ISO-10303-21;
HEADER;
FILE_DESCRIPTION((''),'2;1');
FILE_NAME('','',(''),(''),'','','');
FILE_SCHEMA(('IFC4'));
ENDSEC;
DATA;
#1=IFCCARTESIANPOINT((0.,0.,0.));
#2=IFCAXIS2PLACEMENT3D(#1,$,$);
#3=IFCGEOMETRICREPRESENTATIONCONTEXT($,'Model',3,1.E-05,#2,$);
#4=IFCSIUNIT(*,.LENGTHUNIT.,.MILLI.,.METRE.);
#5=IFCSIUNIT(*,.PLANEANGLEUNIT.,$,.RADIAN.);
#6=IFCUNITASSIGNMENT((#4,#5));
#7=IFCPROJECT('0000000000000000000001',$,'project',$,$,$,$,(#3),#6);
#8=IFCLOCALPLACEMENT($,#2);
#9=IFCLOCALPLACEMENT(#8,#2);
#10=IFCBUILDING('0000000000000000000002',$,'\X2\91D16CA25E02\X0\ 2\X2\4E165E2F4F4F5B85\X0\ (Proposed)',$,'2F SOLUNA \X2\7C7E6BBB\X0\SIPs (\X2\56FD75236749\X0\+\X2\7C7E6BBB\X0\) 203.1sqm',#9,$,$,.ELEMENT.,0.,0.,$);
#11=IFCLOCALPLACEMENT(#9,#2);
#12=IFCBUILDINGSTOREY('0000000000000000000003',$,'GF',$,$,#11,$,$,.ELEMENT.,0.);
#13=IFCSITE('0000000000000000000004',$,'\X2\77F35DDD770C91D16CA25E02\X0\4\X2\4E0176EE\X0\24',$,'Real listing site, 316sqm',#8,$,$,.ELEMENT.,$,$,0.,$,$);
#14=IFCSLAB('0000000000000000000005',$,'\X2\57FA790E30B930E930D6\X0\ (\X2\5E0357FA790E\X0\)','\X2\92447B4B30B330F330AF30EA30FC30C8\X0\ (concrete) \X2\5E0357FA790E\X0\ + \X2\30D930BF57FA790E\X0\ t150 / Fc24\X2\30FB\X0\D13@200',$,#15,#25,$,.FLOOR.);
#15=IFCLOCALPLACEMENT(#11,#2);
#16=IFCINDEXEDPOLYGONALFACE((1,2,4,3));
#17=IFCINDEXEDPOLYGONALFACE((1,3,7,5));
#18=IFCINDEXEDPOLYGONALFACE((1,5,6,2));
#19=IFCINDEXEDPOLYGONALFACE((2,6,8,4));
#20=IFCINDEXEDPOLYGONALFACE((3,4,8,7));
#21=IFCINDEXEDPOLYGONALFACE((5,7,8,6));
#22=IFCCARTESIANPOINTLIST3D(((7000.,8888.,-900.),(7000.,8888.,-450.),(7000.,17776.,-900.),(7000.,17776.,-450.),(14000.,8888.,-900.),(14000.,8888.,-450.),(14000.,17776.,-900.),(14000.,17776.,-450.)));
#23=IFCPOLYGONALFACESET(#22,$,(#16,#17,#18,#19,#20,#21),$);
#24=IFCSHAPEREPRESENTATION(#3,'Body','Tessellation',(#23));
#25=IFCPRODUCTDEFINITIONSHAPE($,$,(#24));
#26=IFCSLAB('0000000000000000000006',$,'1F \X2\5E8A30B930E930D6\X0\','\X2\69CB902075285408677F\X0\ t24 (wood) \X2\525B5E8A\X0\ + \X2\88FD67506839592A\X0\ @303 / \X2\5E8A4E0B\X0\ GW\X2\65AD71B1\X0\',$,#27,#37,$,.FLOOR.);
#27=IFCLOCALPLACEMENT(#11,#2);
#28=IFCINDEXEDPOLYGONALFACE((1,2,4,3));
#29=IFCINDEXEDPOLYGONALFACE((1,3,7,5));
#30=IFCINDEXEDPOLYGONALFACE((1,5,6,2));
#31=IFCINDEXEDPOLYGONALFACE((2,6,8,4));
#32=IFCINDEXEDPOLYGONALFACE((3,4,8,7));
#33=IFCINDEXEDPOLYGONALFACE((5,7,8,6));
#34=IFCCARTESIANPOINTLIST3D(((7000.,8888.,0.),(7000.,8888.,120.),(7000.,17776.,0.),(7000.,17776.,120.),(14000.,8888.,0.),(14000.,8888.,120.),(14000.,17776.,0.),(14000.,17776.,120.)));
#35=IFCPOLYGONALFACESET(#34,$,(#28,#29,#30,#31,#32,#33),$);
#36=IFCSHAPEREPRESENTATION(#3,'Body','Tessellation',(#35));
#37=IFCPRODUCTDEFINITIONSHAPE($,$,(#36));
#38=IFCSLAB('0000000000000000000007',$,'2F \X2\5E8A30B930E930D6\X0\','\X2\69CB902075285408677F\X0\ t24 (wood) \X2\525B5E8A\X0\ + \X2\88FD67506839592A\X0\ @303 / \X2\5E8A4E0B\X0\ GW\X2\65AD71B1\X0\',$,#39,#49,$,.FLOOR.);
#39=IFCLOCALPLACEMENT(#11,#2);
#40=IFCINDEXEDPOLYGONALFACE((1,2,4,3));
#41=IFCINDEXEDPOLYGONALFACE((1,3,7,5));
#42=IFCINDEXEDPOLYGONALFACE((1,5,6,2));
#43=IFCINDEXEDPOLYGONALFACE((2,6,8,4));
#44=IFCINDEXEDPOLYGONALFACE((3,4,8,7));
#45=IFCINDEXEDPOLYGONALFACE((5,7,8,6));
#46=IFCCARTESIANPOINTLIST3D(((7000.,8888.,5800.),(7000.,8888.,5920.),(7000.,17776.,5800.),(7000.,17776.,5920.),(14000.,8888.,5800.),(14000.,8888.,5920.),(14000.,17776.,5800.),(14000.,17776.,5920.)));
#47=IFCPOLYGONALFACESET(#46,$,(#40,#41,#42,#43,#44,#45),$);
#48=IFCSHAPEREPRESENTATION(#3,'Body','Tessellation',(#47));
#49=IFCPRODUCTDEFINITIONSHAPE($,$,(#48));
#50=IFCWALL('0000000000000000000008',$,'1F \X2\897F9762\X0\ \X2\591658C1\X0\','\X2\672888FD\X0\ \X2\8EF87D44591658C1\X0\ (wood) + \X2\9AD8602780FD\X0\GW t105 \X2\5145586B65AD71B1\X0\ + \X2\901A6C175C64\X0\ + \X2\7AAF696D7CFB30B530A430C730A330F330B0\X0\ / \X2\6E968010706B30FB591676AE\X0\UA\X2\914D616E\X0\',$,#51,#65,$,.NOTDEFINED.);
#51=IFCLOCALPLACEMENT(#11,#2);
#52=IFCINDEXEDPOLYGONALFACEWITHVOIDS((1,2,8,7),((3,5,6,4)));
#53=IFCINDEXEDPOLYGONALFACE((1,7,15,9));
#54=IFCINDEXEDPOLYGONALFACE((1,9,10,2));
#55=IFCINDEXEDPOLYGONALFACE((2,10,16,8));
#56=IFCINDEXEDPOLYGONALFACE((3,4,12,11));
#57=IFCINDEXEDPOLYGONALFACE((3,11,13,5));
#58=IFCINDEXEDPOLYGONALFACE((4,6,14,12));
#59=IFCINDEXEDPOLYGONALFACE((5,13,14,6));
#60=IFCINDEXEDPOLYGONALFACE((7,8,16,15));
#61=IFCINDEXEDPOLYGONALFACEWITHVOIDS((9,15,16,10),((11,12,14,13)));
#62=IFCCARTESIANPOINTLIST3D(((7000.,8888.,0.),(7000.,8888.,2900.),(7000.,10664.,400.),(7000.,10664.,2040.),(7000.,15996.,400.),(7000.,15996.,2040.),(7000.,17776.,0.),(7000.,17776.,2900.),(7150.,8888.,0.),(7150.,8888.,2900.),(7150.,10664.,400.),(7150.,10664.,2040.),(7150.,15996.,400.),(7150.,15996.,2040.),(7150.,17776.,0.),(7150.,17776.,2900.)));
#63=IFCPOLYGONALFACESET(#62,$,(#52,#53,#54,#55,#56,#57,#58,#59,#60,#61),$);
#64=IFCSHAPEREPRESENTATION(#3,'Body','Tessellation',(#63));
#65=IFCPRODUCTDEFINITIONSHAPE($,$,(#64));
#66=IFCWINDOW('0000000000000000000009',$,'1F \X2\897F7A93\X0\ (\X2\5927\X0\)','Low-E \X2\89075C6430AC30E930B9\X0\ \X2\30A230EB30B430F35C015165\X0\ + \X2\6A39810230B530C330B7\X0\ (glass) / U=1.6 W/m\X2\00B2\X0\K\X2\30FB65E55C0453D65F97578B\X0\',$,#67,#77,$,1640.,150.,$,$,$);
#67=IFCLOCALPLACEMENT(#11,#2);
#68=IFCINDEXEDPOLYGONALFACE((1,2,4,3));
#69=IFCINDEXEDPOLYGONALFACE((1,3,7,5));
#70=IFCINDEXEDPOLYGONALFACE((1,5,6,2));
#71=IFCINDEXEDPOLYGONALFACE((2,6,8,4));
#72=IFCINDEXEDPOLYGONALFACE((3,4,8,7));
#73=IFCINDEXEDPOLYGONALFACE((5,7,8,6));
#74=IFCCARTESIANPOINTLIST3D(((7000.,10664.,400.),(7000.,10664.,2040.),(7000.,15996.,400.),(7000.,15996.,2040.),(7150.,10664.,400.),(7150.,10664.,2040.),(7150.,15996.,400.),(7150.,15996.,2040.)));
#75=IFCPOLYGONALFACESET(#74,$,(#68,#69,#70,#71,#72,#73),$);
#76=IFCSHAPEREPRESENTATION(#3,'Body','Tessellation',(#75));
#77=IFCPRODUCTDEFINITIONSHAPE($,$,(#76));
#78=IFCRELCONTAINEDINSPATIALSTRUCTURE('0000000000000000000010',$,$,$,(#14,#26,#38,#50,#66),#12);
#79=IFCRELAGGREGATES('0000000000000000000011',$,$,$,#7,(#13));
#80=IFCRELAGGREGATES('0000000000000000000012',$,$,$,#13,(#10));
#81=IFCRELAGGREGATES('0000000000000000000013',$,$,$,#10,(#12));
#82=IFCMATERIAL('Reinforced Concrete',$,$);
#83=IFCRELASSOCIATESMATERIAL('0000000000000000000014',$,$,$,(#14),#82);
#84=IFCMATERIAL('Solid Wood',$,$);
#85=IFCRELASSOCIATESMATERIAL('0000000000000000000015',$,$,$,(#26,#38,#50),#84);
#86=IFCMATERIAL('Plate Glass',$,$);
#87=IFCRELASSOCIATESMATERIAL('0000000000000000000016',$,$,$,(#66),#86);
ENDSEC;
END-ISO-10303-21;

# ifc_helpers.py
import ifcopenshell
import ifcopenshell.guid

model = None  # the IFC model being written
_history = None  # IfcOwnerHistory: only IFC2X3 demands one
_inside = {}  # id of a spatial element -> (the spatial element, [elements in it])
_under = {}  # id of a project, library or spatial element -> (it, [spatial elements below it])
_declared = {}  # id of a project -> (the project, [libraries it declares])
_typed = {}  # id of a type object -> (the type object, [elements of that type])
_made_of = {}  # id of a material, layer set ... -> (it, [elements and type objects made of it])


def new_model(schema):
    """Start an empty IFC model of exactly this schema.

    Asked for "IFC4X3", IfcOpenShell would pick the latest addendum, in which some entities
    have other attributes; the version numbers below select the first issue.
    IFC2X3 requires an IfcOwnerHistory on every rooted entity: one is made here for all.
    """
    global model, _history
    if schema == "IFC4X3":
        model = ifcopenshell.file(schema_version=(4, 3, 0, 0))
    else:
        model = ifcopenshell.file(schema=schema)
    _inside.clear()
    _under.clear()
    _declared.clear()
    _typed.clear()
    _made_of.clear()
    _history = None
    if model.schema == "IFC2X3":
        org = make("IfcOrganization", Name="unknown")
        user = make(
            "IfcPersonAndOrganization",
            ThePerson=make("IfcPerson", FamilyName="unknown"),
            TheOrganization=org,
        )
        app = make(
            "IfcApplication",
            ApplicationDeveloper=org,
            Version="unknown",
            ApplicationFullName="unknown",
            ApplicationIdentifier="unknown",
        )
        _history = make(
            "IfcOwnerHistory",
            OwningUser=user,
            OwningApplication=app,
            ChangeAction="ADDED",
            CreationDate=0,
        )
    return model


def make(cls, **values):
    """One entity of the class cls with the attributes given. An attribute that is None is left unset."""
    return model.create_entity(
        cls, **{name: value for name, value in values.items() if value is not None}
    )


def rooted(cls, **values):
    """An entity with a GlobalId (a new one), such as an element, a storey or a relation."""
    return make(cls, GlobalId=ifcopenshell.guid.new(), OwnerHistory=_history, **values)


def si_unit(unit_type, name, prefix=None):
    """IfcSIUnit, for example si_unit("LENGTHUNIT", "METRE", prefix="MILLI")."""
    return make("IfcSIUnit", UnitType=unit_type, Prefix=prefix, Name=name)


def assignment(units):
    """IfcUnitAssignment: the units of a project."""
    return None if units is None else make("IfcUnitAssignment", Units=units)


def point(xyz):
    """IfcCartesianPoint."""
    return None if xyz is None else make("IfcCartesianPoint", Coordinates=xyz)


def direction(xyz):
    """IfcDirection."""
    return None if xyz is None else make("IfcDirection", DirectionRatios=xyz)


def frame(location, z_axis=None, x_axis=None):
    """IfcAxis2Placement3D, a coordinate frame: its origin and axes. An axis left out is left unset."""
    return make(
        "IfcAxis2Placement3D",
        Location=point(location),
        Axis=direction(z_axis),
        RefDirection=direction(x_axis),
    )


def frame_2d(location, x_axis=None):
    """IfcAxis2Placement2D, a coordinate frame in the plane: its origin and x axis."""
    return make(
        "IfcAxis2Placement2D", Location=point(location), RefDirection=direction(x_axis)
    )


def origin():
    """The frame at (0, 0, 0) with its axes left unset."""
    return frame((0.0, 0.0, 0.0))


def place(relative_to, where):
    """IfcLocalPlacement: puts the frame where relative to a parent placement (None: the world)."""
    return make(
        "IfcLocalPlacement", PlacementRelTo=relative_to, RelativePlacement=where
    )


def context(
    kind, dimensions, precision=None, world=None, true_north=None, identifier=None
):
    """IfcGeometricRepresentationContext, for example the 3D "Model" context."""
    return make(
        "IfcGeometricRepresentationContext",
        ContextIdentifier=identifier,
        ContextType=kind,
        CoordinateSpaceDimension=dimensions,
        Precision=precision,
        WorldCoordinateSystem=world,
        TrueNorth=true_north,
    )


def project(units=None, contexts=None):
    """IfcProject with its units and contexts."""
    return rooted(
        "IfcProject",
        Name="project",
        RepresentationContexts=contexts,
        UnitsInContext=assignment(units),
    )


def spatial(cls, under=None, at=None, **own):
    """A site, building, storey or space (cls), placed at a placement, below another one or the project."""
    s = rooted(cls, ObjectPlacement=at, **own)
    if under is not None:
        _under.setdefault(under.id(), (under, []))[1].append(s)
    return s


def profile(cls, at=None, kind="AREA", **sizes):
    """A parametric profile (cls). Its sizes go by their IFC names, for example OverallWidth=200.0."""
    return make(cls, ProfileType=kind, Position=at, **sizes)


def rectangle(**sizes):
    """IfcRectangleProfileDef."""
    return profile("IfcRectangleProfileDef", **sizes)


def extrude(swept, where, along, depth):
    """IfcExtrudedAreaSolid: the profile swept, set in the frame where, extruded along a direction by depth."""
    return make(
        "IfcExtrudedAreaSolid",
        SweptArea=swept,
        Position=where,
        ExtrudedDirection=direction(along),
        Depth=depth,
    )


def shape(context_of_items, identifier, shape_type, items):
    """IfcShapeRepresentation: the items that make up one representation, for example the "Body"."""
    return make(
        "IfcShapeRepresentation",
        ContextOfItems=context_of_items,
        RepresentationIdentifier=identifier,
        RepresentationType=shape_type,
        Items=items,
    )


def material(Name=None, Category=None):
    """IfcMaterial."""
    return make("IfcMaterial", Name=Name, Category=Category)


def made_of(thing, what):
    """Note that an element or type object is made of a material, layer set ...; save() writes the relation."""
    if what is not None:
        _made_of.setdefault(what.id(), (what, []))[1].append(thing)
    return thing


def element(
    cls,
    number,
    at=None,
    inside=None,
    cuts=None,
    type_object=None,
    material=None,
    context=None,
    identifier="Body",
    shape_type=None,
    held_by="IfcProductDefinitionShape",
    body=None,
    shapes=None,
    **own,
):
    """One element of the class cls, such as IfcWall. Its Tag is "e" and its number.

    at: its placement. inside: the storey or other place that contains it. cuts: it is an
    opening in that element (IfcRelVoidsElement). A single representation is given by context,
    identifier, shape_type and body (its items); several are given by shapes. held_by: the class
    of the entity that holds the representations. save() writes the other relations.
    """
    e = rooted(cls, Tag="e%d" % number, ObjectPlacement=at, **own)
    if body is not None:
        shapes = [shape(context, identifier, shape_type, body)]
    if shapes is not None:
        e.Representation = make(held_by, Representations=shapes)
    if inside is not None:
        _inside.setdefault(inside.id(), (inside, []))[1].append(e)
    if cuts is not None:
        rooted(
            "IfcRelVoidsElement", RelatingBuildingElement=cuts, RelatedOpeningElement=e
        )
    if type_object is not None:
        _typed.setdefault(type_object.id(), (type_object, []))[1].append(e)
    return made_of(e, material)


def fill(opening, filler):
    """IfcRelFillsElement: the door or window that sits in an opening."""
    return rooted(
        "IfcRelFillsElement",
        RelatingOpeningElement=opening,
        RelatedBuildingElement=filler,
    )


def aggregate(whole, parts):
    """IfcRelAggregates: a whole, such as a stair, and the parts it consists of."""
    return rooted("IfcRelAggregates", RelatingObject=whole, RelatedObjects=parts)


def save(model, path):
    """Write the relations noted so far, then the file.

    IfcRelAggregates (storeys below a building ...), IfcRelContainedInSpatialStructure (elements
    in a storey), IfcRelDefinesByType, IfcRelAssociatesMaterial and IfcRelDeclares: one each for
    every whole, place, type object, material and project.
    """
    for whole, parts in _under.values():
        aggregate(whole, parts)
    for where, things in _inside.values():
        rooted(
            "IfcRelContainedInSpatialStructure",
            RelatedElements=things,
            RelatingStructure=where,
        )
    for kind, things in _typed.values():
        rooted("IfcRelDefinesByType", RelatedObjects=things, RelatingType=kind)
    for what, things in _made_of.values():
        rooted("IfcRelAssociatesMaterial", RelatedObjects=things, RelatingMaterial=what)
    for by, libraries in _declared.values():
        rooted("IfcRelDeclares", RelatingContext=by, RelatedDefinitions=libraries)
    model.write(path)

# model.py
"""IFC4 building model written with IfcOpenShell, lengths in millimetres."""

from ifc_helpers import new_model, si_unit, frame, frame_2d, origin, place, context, project, spatial, rectangle, extrude, material, element, fill, save


model = new_model("IFC4")

# Units and contexts
model_context = context("Model", 3, precision=1e-05, world=origin())
ifc_project = project(units=[si_unit("LENGTHUNIT", "METRE", prefix="MILLI"), si_unit("PLANEANGLEUNIT", "RADIAN")], contexts=[model_context])

# Site, building, storey
site_placement = place(None, origin())
site = spatial("IfcSite", under=ifc_project, at=site_placement, Name="石川県金沢市4丁目24", ObjectType="Real listing site, 316sqm", CompositionType="ELEMENT", RefElevation=0.0)
building_placement = place(site_placement, origin())
building = spatial("IfcBuilding", under=site, at=building_placement, Name="金沢市 2世帯住宅 (Proposed)", ObjectType="2F SOLUNA 籾殻SIPs (国産杉+籾殻) 203.1sqm", CompositionType="ELEMENT", ElevationOfRefHeight=0.0, ElevationOfTerrain=0.0)
storey_placement = place(building_placement, origin())
storey = spatial("IfcBuildingStorey", under=building, at=storey_placement, Name="GF", CompositionType="ELEMENT", Elevation=0.0)

# Slabs
ifc_material_1 = material(Name="Reinforced Concrete")
slab_1_placement = place(storey_placement, frame((3500.0, 4444.0, -450.0)))
element("IfcSlab", 1, at=slab_1_placement, inside=storey, material=ifc_material_1, Name="基礎スラブ (布基礎)", Description="鉄筋コンクリート (concrete) 布基礎 + ベタ基礎 t150 / Fc24・D13@200", PredefinedType="FLOOR", context=model_context, shape_type="SweptSolid", body=[
    extrude(rectangle(XDim=7000.0, YDim=8888.0, at=frame_2d((3500.0, 4444.0))), frame((3500.0, 4444.0, -450.0)), (0.0, 0.0, 1.0), 450.0),
])
ifc_material_2 = material(Name="Solid Wood")
slab_2_placement = place(storey_placement, frame((3500.0, 4444.0, 0.0)))
element("IfcSlab", 2, at=slab_2_placement, inside=storey, material=ifc_material_2, Name="1F 床スラブ", Description="構造用合板 t24 (wood) 剛床 + 製材根太 @303 / 床下 GW断熱", PredefinedType="FLOOR", context=model_context, shape_type="SweptSolid", body=[
    extrude(rectangle(XDim=7000.0, YDim=8888.0, at=frame_2d((3500.0, 4444.0))), frame((3500.0, 4444.0, 0.0)), (0.0, 0.0, 1.0), 120.0),
])
slab_3_placement = place(storey_placement, frame((3500.0, 4444.0, 2900.0)))
element("IfcSlab", 3, at=slab_3_placement, inside=storey, material=ifc_material_2, Name="2F 床スラブ", Description="構造用合板 t24 (wood) 剛床 + 製材根太 @303 / 床下 GW断熱", PredefinedType="FLOOR", context=model_context, shape_type="SweptSolid", body=[
    extrude(rectangle(XDim=7000.0, YDim=8888.0, at=frame_2d((3500.0, 4444.0))), frame((3500.0, 4444.0, 2900.0)), (0.0, 0.0, 1.0), 120.0),
])

# Shared definitions
ifc_material_3 = material(Name="Plate Glass")

# Wall, opening, window
wall_1_placement = place(storey_placement, frame((3500.0, 4444.0, 0.0)))
wall_1 = element("IfcWall", 4, at=wall_1_placement, inside=storey, material=ifc_material_2, Name="1F 西面 外壁", Description="木製 軸組外壁 (wood) + 高性能GW t105 充填断熱 + 通気層 + 窯業系サイディング / 準耐火・外皮UA配慮", PredefinedType="NOTDEFINED", context=model_context, shape_type="SweptSolid", body=[
    extrude(rectangle(XDim=150.0, YDim=8888.0, at=frame_2d((75.0, 4444.0))), frame((3500.0, 4444.0, 0.0)), (0.0, 0.0, 1.0), 2900.0),
])
opening_1_placement = place(storey_placement, frame((3500.0, 5332.0, 200.0)))
opening_1 = element("IfcOpeningElement", 5, at=opening_1_placement, cuts=wall_1, PredefinedType="NOTDEFINED", context=model_context, shape_type="SweptSolid", body=[
    extrude(rectangle(XDim=150.0, YDim=5332.0, at=frame_2d((75.0, 2666.0))), frame((3500.0, 5332.0, 200.0)), (0.0, 0.0, 1.0), 1640.0),
])
window_1_placement = place(storey_placement, frame((3500.0, 5332.0, 200.0)))
window_1 = element("IfcWindow", 6, at=window_1_placement, inside=storey, material=ifc_material_3, Name="1F 西窓 (大)", Description="Low-E 複層ガラス アルゴン封入 + 樹脂サッシ (glass) / U=1.6 W/m²K・日射取得型", OverallHeight=1640.0, OverallWidth=150.0, context=model_context, shape_type="SweptSolid", body=[
    extrude(rectangle(XDim=150.0, YDim=5332.0, at=frame_2d((75.0, 2666.0))), frame((3500.0, 5332.0, 200.0)), (0.0, 0.0, 1.0), 1640.0),
])
fill(opening_1, window_1)

save(model, "model.ifc")
